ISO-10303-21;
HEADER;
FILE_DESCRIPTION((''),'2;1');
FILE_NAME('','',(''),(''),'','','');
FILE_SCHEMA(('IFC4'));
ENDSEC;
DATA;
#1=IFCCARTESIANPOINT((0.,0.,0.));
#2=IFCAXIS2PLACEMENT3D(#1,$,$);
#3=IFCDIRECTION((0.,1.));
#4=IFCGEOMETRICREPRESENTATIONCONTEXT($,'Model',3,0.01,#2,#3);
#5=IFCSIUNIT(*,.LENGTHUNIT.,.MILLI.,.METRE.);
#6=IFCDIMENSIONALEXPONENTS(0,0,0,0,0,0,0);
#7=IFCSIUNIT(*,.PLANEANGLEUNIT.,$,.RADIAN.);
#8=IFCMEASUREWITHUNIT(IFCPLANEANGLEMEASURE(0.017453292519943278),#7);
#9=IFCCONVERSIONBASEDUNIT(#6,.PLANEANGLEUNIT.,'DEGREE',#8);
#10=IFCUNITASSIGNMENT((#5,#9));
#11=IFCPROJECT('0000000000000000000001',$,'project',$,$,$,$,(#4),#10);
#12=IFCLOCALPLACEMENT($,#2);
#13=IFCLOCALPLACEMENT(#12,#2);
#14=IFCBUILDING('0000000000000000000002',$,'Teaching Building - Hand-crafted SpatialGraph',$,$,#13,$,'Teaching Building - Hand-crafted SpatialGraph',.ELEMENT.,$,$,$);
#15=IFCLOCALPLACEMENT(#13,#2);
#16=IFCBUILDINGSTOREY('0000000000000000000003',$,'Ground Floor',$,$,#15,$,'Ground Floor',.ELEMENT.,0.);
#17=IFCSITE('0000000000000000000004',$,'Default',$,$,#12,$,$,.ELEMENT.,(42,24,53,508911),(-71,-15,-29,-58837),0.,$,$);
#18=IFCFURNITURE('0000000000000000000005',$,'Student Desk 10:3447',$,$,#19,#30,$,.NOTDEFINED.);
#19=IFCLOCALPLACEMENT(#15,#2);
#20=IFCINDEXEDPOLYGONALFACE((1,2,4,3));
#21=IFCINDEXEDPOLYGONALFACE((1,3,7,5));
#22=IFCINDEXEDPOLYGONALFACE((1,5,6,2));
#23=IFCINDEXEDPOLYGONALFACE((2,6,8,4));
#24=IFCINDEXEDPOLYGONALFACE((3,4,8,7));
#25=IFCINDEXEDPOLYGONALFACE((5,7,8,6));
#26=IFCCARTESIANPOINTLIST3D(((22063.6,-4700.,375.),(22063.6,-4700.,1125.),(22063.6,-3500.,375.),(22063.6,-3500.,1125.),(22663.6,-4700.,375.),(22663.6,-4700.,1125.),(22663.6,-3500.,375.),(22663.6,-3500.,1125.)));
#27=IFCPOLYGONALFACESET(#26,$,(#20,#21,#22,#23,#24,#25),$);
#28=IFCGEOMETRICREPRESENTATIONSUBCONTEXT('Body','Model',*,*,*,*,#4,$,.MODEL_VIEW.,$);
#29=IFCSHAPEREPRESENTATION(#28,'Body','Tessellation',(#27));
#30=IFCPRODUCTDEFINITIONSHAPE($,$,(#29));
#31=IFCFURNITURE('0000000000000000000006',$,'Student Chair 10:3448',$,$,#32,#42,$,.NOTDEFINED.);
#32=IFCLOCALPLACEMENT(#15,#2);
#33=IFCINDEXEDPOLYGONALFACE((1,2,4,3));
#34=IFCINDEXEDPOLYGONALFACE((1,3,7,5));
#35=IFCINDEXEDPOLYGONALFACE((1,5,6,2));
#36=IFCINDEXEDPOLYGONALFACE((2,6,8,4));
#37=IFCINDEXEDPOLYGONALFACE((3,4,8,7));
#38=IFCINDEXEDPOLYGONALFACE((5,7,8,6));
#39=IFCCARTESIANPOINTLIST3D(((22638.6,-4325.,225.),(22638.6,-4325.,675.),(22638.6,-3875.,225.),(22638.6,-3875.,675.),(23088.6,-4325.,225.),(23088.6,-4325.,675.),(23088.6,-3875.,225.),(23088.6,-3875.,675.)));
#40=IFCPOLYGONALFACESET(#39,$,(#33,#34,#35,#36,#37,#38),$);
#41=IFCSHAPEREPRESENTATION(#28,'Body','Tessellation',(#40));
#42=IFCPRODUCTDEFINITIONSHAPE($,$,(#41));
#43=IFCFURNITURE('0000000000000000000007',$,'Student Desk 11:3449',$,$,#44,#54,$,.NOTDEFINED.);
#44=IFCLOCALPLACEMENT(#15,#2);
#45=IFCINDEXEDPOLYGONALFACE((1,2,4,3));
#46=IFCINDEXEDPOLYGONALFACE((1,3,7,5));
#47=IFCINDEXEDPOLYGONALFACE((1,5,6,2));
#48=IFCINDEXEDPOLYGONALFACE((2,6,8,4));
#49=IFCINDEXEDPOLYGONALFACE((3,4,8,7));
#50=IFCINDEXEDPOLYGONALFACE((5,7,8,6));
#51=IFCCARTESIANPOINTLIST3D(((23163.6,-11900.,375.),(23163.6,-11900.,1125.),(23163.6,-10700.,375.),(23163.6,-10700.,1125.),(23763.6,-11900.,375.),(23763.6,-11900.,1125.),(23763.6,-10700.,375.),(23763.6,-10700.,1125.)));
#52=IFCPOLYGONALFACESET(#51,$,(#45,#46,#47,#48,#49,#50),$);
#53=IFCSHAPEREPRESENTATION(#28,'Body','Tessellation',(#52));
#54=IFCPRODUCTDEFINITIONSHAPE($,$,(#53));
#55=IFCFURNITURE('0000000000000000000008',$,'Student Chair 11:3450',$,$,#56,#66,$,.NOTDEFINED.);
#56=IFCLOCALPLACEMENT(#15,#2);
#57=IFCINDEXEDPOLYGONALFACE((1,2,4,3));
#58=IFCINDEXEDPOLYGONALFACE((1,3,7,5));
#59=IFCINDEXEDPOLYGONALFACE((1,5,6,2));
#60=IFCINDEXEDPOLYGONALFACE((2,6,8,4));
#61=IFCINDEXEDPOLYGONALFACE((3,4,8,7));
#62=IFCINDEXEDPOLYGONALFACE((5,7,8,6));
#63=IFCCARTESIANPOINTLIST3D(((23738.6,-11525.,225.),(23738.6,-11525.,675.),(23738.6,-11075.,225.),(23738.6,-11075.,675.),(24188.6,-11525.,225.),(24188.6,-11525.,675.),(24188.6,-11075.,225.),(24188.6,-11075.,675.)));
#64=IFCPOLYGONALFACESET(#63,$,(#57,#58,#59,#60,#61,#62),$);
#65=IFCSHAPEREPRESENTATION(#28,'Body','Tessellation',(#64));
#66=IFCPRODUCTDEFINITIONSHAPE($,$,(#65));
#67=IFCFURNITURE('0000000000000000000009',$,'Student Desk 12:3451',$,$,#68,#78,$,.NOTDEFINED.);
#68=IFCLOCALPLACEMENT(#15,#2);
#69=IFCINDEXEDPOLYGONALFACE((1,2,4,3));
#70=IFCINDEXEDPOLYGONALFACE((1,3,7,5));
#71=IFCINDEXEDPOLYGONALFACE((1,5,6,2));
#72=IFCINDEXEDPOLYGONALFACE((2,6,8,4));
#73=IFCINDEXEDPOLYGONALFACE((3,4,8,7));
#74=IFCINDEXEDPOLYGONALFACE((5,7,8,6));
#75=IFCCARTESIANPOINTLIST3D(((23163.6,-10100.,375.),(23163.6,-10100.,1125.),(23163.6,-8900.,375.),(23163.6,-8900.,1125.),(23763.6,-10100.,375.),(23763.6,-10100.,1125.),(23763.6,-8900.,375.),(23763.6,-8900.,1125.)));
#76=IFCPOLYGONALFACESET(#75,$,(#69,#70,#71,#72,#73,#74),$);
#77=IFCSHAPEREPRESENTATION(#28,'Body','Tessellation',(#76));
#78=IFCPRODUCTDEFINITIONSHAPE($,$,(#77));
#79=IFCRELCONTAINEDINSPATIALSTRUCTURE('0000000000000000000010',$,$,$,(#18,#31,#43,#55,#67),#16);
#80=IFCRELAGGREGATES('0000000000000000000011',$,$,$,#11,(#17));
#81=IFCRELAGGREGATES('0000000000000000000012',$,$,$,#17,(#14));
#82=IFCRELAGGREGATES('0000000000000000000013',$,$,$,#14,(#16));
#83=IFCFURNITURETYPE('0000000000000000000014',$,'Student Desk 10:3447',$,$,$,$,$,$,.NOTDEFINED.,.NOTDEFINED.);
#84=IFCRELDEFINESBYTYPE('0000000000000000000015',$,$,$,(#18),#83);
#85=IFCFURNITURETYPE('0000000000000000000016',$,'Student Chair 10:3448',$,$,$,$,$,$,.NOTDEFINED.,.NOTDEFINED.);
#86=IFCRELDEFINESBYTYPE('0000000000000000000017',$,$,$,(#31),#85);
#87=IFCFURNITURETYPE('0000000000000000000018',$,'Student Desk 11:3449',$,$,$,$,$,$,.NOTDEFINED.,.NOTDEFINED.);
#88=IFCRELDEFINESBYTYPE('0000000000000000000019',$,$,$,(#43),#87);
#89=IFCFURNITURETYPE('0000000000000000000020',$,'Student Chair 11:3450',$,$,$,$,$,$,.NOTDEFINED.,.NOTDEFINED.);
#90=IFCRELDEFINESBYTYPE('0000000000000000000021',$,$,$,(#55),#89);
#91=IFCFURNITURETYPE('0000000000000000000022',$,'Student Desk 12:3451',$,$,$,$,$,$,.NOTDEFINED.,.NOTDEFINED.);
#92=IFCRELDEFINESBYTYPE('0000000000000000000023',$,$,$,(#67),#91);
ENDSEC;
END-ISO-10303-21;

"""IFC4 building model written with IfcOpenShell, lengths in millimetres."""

from ifc_helpers import new_model, entity, si_unit, converted_unit, direction, frame, origin, origin_2d_with_axis, place, context, subcontext, project, spatial, rectangle, extrude, type_object, element, save


model = new_model("IFC4")

# Units and contexts
model_context = context("Model", 3, precision=0.01, world=origin(), true_north=direction((0.0, 1.0)))
body_context = subcontext(model_context, "Body", "Model", "MODEL_VIEW")
ifc_project = project(units=[si_unit("LENGTHUNIT", "METRE", prefix="MILLI"), converted_unit("PLANEANGLEUNIT", "DEGREE", entity("IfcPlaneAngleMeasure", 0.017453292519943278), si_unit("PLANEANGLEUNIT", "RADIAN"), dimensions=[0, 0, 0, 0, 0, 0, 0])], contexts=[model_context])

# Site, building, storey
site_placement = place(None, origin())
site = spatial("IfcSite", under=ifc_project, at=site_placement, Name="Default", CompositionType="ELEMENT", RefLatitude=(42, 24, 53, 508911), RefLongitude=(-71, -15, -29, -58837), RefElevation=0.0)
building_placement = place(site_placement, origin())
building = spatial("IfcBuilding", under=site, at=building_placement, Name="Teaching Building - Hand-crafted SpatialGraph", LongName="Teaching Building - Hand-crafted SpatialGraph", CompositionType="ELEMENT")
storey_placement = place(building_placement, origin())
storey = spatial("IfcBuildingStorey", under=building, at=storey_placement, Name="Ground Floor", LongName="Ground Floor", CompositionType="ELEMENT", Elevation=0.0)

# Furniture
furniture_type_1 = type_object("IfcFurnitureType", Name="Student Desk 10:3447", PredefinedType="NOTDEFINED")
furniture_1_placement = place(storey_placement, origin())
element("IfcFurniture", 1, at=furniture_1_placement, inside=storey, type_object=furniture_type_1, Name="Student Desk 10:3447", PredefinedType="NOTDEFINED", context=body_context, shape_type="SweptSolid", body=[
    extrude(rectangle(XDim=1200.0, YDim=600.0, at=origin_2d_with_axis()), frame((22363.6, -4100.0, 375.0), z_axis=(0.0, 0.0, 1.0), x_axis=(0.0, 1.0, 0.0)), (0.0, 0.0, 1.0), 750.0),
])
furniture_type_2 = type_object("IfcFurnitureType", Name="Student Chair 10:3448", PredefinedType="NOTDEFINED")
furniture_2_placement = place(storey_placement, origin())
element("IfcFurniture", 2, at=furniture_2_placement, inside=storey, type_object=furniture_type_2, Name="Student Chair 10:3448", PredefinedType="NOTDEFINED", context=body_context, shape_type="SweptSolid", body=[
    extrude(rectangle(XDim=450.0, YDim=450.0, at=origin_2d_with_axis()), frame((22863.6, -4100.0, 225.0)), (0.0, 0.0, 1.0), 450.0),
])
furniture_type_3 = type_object("IfcFurnitureType", Name="Student Desk 11:3449", PredefinedType="NOTDEFINED")
furniture_3_placement = place(storey_placement, origin())
element("IfcFurniture", 3, at=furniture_3_placement, inside=storey, type_object=furniture_type_3, Name="Student Desk 11:3449", PredefinedType="NOTDEFINED", context=body_context, shape_type="SweptSolid", body=[
    extrude(rectangle(XDim=1200.0, YDim=600.0, at=origin_2d_with_axis()), frame((23463.6, -11300.0, 375.0), z_axis=(0.0, 0.0, 1.0), x_axis=(0.0, 1.0, 0.0)), (0.0, 0.0, 1.0), 750.0),
])
furniture_type_4 = type_object("IfcFurnitureType", Name="Student Chair 11:3450", PredefinedType="NOTDEFINED")
furniture_4_placement = place(storey_placement, origin())
element("IfcFurniture", 4, at=furniture_4_placement, inside=storey, type_object=furniture_type_4, Name="Student Chair 11:3450", PredefinedType="NOTDEFINED", context=body_context, shape_type="SweptSolid", body=[
    extrude(rectangle(XDim=450.0, YDim=450.0, at=origin_2d_with_axis()), frame((23963.6, -11300.0, 225.0)), (0.0, 0.0, 1.0), 450.0),
])
furniture_type_5 = type_object("IfcFurnitureType", Name="Student Desk 12:3451", PredefinedType="NOTDEFINED")
furniture_5_placement = place(storey_placement, origin())
element("IfcFurniture", 5, at=furniture_5_placement, inside=storey, type_object=furniture_type_5, Name="Student Desk 12:3451", PredefinedType="NOTDEFINED", context=body_context, shape_type="SweptSolid", body=[
    extrude(rectangle(XDim=1200.0, YDim=600.0, at=origin_2d_with_axis()), frame((23463.6, -9500.0, 375.0), z_axis=(0.0, 0.0, 1.0), x_axis=(0.0, 1.0, 0.0)), (0.0, 0.0, 1.0), 750.0),
])

save(model, "model.ifc")
